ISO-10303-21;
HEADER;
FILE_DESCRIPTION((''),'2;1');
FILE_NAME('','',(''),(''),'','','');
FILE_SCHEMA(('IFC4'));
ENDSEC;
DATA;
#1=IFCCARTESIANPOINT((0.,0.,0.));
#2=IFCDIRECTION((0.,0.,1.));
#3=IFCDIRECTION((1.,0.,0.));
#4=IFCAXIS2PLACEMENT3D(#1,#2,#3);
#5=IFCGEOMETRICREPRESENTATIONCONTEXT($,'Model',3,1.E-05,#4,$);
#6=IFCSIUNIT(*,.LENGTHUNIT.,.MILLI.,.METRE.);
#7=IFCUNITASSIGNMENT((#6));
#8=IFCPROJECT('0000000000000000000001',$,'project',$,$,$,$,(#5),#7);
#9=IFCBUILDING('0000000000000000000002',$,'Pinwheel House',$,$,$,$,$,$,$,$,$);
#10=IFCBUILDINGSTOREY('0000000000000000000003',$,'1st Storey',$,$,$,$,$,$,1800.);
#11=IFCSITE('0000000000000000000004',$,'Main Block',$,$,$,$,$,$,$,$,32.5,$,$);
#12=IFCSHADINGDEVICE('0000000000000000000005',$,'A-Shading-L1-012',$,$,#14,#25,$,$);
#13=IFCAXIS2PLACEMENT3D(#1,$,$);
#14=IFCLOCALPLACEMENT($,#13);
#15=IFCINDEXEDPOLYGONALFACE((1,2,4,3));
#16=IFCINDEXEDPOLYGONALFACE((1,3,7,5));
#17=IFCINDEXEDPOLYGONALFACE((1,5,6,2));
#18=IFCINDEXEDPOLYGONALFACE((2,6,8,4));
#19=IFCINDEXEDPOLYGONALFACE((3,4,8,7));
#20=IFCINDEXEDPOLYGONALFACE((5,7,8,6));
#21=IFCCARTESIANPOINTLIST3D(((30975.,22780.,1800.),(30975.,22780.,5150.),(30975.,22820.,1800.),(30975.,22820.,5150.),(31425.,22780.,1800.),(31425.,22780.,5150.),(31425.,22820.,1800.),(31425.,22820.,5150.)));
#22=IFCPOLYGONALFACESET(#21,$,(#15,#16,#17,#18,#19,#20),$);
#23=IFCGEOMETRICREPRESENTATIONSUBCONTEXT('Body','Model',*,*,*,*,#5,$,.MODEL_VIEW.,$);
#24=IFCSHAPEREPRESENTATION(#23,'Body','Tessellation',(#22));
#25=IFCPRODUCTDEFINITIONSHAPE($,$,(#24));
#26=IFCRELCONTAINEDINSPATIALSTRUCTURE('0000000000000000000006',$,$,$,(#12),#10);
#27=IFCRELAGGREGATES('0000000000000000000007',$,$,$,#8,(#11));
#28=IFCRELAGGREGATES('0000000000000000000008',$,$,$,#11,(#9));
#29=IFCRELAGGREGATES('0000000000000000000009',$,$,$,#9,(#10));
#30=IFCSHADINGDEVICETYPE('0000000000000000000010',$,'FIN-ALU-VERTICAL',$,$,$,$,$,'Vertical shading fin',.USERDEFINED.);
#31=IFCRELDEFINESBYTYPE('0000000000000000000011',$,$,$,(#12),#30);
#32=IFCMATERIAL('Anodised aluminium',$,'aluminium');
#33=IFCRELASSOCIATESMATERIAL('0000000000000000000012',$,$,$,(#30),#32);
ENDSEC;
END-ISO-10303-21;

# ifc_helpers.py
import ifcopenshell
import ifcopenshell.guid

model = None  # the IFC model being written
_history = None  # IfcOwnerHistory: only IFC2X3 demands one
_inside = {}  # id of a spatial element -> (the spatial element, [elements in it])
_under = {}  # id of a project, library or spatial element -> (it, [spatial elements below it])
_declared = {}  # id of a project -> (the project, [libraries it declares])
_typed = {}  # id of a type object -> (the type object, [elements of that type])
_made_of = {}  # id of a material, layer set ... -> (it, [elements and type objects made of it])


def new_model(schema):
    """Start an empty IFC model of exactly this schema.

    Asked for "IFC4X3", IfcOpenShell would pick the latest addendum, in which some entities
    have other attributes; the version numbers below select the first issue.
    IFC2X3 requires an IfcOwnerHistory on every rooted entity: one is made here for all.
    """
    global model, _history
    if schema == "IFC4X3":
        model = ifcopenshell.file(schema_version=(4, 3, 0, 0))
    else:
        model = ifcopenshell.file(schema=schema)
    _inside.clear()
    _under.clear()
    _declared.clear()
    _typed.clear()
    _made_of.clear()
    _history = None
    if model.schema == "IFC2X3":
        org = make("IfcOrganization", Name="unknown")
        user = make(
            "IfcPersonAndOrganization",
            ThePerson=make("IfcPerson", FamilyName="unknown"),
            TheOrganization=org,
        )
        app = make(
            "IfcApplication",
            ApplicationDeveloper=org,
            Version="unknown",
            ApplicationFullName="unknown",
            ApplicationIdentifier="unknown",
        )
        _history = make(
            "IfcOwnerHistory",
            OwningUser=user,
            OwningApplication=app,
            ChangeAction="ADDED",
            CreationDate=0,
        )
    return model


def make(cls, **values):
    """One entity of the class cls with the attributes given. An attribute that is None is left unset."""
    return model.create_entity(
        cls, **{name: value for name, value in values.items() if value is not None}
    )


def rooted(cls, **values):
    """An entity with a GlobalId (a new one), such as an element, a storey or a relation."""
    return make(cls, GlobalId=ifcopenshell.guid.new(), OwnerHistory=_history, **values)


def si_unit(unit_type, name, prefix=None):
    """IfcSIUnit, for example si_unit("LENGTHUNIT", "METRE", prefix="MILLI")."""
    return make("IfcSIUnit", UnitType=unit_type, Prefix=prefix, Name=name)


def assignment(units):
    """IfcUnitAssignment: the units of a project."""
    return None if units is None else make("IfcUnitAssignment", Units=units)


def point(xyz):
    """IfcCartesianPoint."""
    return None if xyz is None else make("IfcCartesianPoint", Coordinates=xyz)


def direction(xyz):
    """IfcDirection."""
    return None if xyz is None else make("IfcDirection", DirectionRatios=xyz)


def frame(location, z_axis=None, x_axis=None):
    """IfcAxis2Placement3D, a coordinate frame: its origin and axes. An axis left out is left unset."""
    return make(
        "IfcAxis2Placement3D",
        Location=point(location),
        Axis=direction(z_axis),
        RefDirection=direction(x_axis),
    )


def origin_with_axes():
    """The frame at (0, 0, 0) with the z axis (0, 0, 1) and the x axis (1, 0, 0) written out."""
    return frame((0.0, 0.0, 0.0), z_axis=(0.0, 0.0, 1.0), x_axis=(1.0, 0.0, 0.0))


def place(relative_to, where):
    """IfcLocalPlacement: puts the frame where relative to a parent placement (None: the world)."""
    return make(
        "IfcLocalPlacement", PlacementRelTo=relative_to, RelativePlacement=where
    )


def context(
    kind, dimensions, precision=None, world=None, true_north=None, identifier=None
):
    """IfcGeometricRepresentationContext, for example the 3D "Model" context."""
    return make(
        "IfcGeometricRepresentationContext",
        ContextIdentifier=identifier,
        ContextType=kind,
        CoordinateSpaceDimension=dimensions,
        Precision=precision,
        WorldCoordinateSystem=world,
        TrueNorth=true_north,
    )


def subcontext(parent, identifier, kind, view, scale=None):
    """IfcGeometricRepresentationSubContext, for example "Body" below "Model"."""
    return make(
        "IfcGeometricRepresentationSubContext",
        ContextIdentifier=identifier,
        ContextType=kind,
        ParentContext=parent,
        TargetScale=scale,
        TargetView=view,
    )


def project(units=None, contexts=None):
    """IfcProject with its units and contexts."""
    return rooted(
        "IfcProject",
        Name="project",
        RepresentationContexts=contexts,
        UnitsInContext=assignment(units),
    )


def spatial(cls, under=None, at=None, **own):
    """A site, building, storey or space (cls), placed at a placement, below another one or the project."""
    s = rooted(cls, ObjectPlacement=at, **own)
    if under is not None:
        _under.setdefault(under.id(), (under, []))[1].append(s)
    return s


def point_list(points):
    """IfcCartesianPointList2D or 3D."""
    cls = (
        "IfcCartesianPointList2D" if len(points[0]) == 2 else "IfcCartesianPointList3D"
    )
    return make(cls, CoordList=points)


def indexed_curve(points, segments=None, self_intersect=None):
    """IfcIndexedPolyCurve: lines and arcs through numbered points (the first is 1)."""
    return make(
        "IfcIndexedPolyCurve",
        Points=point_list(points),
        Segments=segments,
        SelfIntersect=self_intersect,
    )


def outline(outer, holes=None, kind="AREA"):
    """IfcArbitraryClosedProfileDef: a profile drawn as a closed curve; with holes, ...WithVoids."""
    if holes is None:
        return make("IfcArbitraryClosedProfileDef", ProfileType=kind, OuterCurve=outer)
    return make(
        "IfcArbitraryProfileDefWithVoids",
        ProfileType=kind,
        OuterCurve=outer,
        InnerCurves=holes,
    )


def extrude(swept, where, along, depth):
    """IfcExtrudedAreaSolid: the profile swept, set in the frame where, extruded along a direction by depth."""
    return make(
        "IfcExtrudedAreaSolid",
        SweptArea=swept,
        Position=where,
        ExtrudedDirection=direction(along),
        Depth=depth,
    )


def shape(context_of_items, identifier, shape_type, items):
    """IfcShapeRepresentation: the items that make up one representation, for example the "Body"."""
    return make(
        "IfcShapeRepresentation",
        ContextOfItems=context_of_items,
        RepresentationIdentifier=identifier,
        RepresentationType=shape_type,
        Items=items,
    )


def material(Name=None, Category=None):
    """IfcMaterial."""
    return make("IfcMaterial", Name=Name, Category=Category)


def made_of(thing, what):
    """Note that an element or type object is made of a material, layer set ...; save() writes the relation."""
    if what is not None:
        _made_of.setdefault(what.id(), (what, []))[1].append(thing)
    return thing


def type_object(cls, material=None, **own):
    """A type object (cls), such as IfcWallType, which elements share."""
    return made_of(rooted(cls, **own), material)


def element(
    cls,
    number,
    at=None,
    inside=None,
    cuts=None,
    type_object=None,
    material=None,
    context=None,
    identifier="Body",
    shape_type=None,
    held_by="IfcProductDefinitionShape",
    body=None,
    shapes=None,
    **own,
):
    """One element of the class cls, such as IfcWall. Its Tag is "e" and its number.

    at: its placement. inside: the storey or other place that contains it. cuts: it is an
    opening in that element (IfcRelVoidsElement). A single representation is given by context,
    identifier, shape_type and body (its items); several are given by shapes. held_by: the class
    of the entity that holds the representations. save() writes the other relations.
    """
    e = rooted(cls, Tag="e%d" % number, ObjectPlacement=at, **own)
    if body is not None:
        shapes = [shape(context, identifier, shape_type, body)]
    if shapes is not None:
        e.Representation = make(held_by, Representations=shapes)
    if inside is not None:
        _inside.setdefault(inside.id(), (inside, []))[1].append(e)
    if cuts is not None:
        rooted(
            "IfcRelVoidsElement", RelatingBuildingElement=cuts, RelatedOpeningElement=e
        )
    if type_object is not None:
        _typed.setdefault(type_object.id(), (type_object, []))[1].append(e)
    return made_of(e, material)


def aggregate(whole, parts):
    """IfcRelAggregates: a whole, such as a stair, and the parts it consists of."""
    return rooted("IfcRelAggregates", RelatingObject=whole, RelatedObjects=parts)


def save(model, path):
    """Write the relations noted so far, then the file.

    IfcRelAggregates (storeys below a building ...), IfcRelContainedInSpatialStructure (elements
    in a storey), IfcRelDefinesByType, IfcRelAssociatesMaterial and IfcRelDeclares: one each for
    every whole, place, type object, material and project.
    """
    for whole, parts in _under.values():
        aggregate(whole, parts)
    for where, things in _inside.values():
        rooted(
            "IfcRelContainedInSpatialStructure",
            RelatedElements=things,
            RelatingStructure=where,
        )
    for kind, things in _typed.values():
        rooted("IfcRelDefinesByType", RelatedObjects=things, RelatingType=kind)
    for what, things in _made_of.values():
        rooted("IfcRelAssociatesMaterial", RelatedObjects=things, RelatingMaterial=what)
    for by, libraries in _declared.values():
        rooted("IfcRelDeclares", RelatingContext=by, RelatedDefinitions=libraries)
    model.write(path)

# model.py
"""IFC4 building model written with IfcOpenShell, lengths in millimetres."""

from ifc_helpers import new_model, si_unit, frame, origin_with_axes, place, context, subcontext, project, spatial, indexed_curve, outline, extrude, material, type_object, element, save


model = new_model("IFC4")

# Units and contexts
model_context = context("Model", 3, precision=1e-05, world=origin_with_axes())
body_context = subcontext(model_context, "Body", "Model", "MODEL_VIEW")
ifc_project = project(units=[si_unit("LENGTHUNIT", "METRE", prefix="MILLI")], contexts=[model_context])

# Site, building, storey
site = spatial("IfcSite", under=ifc_project, Name="Main Block", RefElevation=32.5)
building = spatial("IfcBuilding", under=site, Name="Pinwheel House")
storey = spatial("IfcBuildingStorey", under=building, Name="1st Storey", Elevation=1800.0)

# Shared definitions
ifc_material_1 = material(Name="Anodised aluminium", Category="aluminium")

# Shading device
shading_device_type = type_object("IfcShadingDeviceType", Name="FIN-ALU-VERTICAL", ElementType="Vertical shading fin", PredefinedType="USERDEFINED", material=ifc_material_1)
for number, where, z_axis, x_axis, name in (
    (1, (31200.0, 22800.0, 1800.0), (0.0, 0.0, 1.0), (0.0, 1.0, 0.0), "A-Shading-L1-012"),
):
    element("IfcShadingDevice", number, at=place(None, frame(where, z_axis=z_axis, x_axis=x_axis)), inside=storey, type_object=shading_device_type, Name=name, context=body_context, shape_type="SweptSolid", body=[
        extrude(outline(indexed_curve([(-20.0, -225.0), (20.0, -225.0), (20.0, 225.0), (-20.0, 225.0)])), None, (0.0, 0.0, 1.0), 3350.0),
    ])

save(model, "model.ifc")
